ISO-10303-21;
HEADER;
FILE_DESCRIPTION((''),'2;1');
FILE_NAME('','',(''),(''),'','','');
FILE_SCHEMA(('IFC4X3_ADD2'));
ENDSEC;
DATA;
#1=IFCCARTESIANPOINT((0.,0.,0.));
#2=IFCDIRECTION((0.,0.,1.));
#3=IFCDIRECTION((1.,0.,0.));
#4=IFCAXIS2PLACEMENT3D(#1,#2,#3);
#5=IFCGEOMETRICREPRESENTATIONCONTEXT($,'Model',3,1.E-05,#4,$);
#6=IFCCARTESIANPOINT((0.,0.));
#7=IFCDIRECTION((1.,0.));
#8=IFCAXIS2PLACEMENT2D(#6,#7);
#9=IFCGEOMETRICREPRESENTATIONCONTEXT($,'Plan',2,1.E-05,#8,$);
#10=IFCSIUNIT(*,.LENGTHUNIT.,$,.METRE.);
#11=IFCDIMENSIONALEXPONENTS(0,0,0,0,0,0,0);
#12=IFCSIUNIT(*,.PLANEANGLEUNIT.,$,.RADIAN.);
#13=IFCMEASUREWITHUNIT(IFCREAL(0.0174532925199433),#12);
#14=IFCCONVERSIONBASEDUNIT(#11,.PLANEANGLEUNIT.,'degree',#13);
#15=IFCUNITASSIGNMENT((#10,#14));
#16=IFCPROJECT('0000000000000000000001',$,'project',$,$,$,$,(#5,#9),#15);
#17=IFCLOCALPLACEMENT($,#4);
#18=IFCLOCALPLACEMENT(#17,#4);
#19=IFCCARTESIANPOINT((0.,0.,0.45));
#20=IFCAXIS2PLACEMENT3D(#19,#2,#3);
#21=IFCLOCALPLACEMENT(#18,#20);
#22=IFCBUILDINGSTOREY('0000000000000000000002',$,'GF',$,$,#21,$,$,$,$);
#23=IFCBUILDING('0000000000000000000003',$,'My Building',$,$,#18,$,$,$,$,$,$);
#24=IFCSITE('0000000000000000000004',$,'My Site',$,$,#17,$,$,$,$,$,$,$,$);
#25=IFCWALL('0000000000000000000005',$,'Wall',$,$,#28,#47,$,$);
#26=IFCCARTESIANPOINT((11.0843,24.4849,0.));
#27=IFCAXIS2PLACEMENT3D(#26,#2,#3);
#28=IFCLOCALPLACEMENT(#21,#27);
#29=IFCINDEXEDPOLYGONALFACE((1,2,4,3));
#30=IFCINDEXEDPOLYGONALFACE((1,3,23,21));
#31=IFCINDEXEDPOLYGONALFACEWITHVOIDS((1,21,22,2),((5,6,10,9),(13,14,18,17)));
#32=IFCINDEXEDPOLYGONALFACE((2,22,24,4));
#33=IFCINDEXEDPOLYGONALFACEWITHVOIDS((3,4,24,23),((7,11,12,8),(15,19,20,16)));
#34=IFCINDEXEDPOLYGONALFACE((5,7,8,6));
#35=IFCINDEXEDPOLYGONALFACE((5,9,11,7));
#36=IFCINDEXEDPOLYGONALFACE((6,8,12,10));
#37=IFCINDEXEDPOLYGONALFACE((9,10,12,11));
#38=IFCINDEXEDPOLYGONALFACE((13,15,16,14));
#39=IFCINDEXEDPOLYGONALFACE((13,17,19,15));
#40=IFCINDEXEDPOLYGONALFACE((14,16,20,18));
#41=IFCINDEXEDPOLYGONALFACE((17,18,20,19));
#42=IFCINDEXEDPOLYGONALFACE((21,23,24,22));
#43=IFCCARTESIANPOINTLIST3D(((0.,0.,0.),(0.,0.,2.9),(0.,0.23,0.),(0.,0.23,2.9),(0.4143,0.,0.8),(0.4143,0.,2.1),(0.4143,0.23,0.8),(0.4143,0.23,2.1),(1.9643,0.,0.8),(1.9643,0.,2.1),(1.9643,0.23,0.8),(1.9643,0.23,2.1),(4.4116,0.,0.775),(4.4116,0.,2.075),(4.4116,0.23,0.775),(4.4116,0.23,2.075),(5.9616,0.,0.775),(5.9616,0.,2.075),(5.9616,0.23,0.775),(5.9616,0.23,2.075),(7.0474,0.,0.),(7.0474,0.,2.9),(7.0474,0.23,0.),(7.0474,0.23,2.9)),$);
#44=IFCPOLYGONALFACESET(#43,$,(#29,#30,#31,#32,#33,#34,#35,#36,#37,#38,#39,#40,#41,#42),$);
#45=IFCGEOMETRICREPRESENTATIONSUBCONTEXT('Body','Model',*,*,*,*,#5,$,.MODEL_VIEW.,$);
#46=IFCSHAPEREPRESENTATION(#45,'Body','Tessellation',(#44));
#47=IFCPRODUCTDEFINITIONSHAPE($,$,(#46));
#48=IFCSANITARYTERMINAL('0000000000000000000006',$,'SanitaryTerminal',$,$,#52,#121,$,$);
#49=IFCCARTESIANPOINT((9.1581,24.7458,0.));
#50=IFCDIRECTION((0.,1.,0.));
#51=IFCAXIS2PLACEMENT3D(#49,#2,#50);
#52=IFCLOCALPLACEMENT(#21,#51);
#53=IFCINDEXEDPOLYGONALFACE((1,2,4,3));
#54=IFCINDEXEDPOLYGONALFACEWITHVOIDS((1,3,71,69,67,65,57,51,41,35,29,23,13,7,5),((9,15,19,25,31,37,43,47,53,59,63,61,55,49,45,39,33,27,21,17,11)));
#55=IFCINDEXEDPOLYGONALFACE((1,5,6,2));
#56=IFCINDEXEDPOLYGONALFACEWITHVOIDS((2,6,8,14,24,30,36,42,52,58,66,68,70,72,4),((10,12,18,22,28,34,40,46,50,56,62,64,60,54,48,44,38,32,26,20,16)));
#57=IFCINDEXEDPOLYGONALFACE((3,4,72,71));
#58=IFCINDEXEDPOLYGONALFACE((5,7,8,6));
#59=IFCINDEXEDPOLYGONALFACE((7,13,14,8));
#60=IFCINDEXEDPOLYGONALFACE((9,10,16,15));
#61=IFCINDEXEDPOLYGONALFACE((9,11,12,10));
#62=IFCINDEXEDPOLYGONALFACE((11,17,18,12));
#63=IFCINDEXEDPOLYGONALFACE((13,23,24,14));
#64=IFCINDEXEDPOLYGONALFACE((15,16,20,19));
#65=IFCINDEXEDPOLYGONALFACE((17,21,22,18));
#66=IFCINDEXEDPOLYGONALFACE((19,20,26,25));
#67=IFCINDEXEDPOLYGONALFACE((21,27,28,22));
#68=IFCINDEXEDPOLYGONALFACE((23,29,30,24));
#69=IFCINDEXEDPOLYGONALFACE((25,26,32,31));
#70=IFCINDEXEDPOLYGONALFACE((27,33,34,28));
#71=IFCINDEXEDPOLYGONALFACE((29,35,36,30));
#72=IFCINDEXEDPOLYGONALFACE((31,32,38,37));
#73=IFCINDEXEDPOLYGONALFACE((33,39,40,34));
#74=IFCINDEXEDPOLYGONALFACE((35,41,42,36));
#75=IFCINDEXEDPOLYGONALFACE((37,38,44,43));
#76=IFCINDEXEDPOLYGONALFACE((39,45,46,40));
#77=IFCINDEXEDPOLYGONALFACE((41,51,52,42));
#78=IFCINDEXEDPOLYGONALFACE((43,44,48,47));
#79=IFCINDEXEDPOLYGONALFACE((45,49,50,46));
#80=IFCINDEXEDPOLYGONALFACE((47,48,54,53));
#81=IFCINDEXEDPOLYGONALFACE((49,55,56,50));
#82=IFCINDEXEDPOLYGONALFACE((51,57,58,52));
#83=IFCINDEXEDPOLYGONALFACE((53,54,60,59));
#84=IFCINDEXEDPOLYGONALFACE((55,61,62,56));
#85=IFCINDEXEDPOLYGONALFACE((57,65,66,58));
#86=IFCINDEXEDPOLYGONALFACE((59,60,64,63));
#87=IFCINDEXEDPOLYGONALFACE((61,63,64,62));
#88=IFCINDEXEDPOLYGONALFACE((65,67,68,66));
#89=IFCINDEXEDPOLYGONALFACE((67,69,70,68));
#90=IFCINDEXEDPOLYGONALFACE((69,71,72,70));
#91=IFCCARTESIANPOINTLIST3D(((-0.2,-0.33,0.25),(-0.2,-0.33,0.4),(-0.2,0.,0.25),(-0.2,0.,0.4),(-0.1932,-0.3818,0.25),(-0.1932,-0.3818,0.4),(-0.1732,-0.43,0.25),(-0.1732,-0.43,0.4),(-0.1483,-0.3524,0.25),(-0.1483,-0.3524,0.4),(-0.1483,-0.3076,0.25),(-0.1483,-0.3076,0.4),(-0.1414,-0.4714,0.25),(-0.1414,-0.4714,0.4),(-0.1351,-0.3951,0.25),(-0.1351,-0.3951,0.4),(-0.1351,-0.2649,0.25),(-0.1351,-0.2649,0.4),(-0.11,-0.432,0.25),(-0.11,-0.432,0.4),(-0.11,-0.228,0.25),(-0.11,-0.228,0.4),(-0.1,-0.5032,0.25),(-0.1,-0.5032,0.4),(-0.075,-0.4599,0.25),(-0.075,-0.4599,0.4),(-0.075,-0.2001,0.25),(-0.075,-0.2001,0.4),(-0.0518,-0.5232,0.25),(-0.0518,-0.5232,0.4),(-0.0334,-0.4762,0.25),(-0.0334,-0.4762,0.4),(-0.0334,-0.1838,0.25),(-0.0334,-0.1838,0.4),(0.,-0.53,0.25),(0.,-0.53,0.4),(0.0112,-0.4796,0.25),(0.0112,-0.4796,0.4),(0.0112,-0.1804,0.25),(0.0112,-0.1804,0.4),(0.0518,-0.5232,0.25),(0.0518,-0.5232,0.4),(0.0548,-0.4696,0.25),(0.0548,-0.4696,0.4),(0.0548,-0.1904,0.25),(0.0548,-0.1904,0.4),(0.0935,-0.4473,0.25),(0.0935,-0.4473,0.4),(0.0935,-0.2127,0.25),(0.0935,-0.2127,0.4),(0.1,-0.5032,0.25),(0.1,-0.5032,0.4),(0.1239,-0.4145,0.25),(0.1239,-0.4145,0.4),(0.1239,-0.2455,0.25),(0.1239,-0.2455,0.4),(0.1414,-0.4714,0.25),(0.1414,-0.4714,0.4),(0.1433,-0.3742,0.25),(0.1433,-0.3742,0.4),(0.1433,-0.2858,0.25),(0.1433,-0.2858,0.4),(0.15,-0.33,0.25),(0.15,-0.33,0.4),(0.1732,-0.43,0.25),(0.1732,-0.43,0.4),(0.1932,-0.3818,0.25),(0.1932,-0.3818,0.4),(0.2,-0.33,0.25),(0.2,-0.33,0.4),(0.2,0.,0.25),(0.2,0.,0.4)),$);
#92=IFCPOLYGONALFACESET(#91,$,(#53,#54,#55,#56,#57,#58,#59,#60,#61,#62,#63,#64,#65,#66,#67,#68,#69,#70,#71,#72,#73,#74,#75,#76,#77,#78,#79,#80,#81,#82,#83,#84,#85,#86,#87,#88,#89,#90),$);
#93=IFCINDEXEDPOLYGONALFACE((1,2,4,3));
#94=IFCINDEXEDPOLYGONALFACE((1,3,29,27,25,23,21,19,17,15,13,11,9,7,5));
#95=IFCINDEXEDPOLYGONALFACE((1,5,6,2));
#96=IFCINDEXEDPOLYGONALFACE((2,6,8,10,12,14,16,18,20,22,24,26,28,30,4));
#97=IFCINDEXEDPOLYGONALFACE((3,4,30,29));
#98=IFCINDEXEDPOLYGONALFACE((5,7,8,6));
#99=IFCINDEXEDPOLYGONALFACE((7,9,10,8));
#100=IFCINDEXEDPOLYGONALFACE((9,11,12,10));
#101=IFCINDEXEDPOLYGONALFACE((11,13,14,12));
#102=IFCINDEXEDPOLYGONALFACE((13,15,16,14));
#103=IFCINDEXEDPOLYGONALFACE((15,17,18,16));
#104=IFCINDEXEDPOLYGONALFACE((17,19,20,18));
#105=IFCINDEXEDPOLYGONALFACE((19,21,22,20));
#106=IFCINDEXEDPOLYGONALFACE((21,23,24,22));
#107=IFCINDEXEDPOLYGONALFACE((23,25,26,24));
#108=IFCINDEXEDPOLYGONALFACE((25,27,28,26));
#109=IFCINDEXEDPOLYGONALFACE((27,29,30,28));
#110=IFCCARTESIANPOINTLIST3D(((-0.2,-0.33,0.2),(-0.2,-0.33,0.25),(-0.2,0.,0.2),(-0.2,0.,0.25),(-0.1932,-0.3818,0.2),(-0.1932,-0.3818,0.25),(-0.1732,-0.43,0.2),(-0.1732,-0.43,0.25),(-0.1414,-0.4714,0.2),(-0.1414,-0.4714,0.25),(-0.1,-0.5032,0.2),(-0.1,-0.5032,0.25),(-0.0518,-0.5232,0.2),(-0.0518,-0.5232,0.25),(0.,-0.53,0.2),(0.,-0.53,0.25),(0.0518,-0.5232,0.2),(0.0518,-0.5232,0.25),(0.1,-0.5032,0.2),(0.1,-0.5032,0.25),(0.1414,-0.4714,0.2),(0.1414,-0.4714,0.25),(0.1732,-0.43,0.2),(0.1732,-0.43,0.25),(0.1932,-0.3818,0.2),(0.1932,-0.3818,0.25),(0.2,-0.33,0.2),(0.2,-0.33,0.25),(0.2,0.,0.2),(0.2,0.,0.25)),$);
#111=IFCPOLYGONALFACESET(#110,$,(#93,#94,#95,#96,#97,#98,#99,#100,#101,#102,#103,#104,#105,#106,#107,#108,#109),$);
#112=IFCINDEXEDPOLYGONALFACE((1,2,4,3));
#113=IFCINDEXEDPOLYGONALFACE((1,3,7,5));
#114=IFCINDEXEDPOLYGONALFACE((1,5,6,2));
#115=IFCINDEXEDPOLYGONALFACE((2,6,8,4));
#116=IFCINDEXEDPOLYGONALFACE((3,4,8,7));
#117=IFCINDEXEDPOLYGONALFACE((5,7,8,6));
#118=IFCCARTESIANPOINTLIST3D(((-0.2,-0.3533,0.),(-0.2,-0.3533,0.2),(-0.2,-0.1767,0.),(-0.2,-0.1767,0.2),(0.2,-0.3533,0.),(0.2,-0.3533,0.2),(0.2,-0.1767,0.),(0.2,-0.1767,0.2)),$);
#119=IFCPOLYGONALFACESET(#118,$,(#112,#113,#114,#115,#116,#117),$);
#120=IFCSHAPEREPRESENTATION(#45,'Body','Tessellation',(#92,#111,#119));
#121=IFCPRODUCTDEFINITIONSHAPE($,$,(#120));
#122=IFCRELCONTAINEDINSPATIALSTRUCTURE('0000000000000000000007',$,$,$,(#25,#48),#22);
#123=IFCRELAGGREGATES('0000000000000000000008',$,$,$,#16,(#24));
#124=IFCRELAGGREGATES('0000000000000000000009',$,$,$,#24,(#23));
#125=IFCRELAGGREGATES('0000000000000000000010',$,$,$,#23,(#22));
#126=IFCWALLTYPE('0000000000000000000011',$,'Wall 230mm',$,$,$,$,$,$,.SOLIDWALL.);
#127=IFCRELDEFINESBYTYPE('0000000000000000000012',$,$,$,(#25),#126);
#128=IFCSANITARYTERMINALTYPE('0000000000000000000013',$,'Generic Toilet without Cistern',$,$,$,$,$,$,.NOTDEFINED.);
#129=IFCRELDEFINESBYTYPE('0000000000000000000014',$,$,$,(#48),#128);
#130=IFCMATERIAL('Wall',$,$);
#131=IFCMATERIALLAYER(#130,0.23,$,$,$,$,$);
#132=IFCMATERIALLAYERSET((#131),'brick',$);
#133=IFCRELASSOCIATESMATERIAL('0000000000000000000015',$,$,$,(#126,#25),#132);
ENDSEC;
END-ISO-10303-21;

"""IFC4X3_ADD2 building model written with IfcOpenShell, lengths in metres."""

from ifc_helpers import new_model, entity, si_unit, converted_unit, frame, frame_2d, origin_with_axes, origin_2d_with_axis, place, context, subcontext, project, spatial, line, arc, indexed_curve, circle_curve, outline, extrude, shape, source, transform, mapped, material, layer, layer_set, layer_usage, type_object, type_shapes, element, save


model = new_model("IFC4X3_ADD2")

# Units and contexts
model_context = context("Model", 3, precision=1e-05, world=origin_with_axes())
plan_context = context("Plan", 2, precision=1e-05, world=origin_2d_with_axis())
body_context_1 = subcontext(model_context, "Body", "Model", "MODEL_VIEW")
body_context_2 = subcontext(plan_context, "Body", "Plan", "PLAN_VIEW")
ifc_project = project(units=[si_unit("LENGTHUNIT", "METRE"), converted_unit("PLANEANGLEUNIT", "degree", entity("IfcReal", 0.0174532925199433), si_unit("PLANEANGLEUNIT", "RADIAN"), dimensions=[0, 0, 0, 0, 0, 0, 0])], contexts=[model_context, plan_context])

# Site, building, storey
site_placement = place(None, origin_with_axes())
site = spatial("IfcSite", under=ifc_project, at=site_placement, Name="My Site")
building_placement = place(site_placement, origin_with_axes())
building = spatial("IfcBuilding", under=site, at=building_placement, Name="My Building")
storey_placement = place(building_placement, frame((0.0, 0.0, 0.45), z_axis=(0.0, 0.0, 1.0), x_axis=(1.0, 0.0, 0.0)))
storey = spatial("IfcBuildingStorey", under=building, at=storey_placement, Name="GF")

# Shared definitions
ifc_material_1 = material(Name="Wall")
ifc_layer_1 = layer(ifc_material_1, 0.23)
ifc_layer_set_1 = layer_set([ifc_layer_1], Name="brick")
wall_type_1 = type_object("IfcWallType", Name="Wall 230mm", PredefinedType="SOLIDWALL", material=ifc_layer_set_1)

# Wall, openings
ifc_layer_usage_1 = layer_usage(ifc_layer_set_1, "AXIS2", "POSITIVE", 0.0)
wall_1_placement = place(storey_placement, frame((11.0843, 24.4849, 0.0), z_axis=(0.0, 0.0, 1.0), x_axis=(1.0, 0.0, 0.0)))
wall_1 = element("IfcWall", 1, at=wall_1_placement, inside=storey, type_object=wall_type_1, material=ifc_layer_usage_1, Name="Wall", context=body_context_1, shape_type="SweptSolid", body=[
    extrude(outline(indexed_curve([(0.0, 0.0), (0.0, 0.23), (7.0474, 0.23), (7.0474, 0.0), (0.0, 0.0)], self_intersect=False)), origin_with_axes(), (0.0, 0.0, 1.0), 2.9),
])
shared_shape_1 = source(origin_with_axes(), body_context_1, "Body", "SweptSolid", [
    extrude(outline(indexed_curve([(0.0, 0.0), (1.55, 0.0), (1.55, 1.3), (0.0, 1.3)], segments=[line(1, 2, 3, 4, 1)])), frame((-0.775, -0.6, 0.0), z_axis=(0.0, -1.0, 0.0), x_axis=(1.0, 0.0, 0.0)), (0.0, 0.0, -1.0), 1.2),
])
opening_1_placement = place(wall_1_placement, frame((5.1866, 0.2, 0.775), z_axis=(0.0, 0.0, 1.0), x_axis=(-1.0, 0.0, 0.0)))
element("IfcOpeningElement", 2, at=opening_1_placement, cuts=wall_1, PredefinedType="OPENING", context=body_context_1, shape_type="MappedRepresentation", body=[
    mapped(shared_shape_1, transform((0.0, 0.0, 0.0), x_axis=(1.0, 0.0, 0.0), y_axis=(0.0, 1.0, 0.0), z_axis=(0.0, 0.0, 1.0), scale=1.0)),
])
opening_2_placement = place(wall_1_placement, frame((1.1893, 0.0, 0.8), z_axis=(0.0, 0.0, 1.0), x_axis=(1.0, 0.0, 0.0)))
element("IfcOpeningElement", 3, at=opening_2_placement, cuts=wall_1, PredefinedType="OPENING", context=body_context_1, shape_type="MappedRepresentation", body=[
    mapped(shared_shape_1, transform((0.0, 0.0, 0.0), x_axis=(1.0, 0.0, 0.0), y_axis=(0.0, 1.0, 0.0), z_axis=(0.0, 0.0, 1.0), scale=1.0)),
])

# Sanitary terminal
sanitary_terminal_type_1 = type_object("IfcSanitaryTerminalType", Name="Generic Toilet without Cistern", PredefinedType="NOTDEFINED")
shared_shape_2 = source(origin_with_axes(), body_context_1, "Body", "SweptSolid", [
    extrude(outline(indexed_curve([(-0.2, 0.0), (0.2, 0.0), (0.2, -0.33), (0.1414, -0.4714), (0.0, -0.53), (-0.1414, -0.4714), (-0.2, -0.33)], segments=[line(1, 2), line(2, 3), arc(3, 4, 5), arc(5, 6, 7), line(7, 1)]), holes=[circle_curve(frame_2d((0.0, -0.33)), 0.15)]), frame((0.0, 0.0, 0.25), z_axis=(0.0, 0.0, 1.0), x_axis=(1.0, 0.0, 0.0)), (0.0, 0.0, 1.0), 0.15),
    extrude(outline(indexed_curve([(-0.2, 0.0), (0.2, 0.0), (0.2, -0.33), (0.1414, -0.4714), (0.0, -0.53), (-0.1414, -0.4714), (-0.2, -0.33)], segments=[line(1, 2), line(2, 3), arc(3, 4, 5), arc(5, 6, 7), line(7, 1)])), frame((0.0, 0.0, 0.2), z_axis=(0.0, 0.0, 1.0), x_axis=(1.0, 0.0, 0.0)), (0.0, 0.0, 1.0), 0.05),
    extrude(outline(indexed_curve([(-0.2, -0.1767), (0.2, -0.1767), (0.2, -0.3533), (-0.2, -0.3533)], segments=[line(1, 2, 3, 4, 1)])), origin_with_axes(), (0.0, 0.0, 1.0), 0.2),
])
shared_shape_3 = source(origin_with_axes(), body_context_2, "Body", "Annotation2D", [
    entity("IfcGeometricCurveSet", [entity("IfcIndexedPolyCurve", entity("IfcCartesianPointList2D", [[-0.1068, -0.124], [-0.0957, -0.1129], [-0.0804, -0.1088], [0.0804, -0.1088], [0.0957, -0.1129], [0.1068, -0.124], [0.1109, -0.1393], [0.1109, -0.3476], [0.1025, -0.3926], [0.0784, -0.4308], [0.0424, -0.4563], [0.0, -0.4652], [-0.0424, -0.4563], [-0.0784, -0.4308], [-0.1025, -0.3926], [-0.1109, -0.3476], [-0.1109, -0.1393]]), [entity("IfcLineIndex", [1, 2, 3, 4, 5, 6, 7, 8, 9, 10, 11, 12, 13, 14, 15, 16, 17, 1])]), entity("IfcIndexedPolyCurve", entity("IfcCartesianPointList2D", [[-0.1962, -0.2314], [-0.1848, -0.301], [-0.1764, -0.3339], [-0.1663, -0.3651], [-0.1546, -0.3944], [-0.1414, -0.4213], [-0.1269, -0.4458], [-0.1111, -0.4675], [-0.0943, -0.4862], [-0.0765, -0.5018], [-0.0581, -0.514], [-0.039, -0.5229], [-0.0196, -0.5282], [0.0, -0.53], [0.0196, -0.5282], [0.039, -0.5229], [0.0581, -0.514], [0.0765, -0.5018], [0.0943, -0.4862], [0.1111, -0.4675], [0.1269, -0.4458], [0.1414, -0.4213], [0.1546, -0.3944], [0.1663, -0.3651], [0.1764, -0.3339], [0.1848, -0.301], [0.1962, -0.2314], [0.2, -0.159], [0.1872, 0.0], [-0.1872, 0.0], [-0.2, -0.159]]), [entity("IfcLineIndex", [1, 2, 3, 4, 5, 6, 7, 8, 9, 10, 11, 12, 13, 14, 15, 16, 17, 18, 19, 20, 21, 22, 23, 24, 25, 26, 27, 28, 29, 30, 31, 1])])]),
])
type_shapes(sanitary_terminal_type_1, [shared_shape_2, shared_shape_3])
for number, where, z_axis, x_axis, name in (
    (4, (9.1581, 24.7458, 0.0), (0.0, 0.0, 1.0), (0.0, 1.0, 0.0), "SanitaryTerminal"),
):
    element("IfcSanitaryTerminal", number, at=place(storey_placement, frame(where, z_axis=z_axis, x_axis=x_axis)), inside=storey, type_object=sanitary_terminal_type_1, Name=name, shapes=[
        shape(body_context_1, "Body", "MappedRepresentation", [mapped(shared_shape_2, transform((0.0, 0.0, 0.0), x_axis=(1.0, 0.0, 0.0), y_axis=(0.0, 1.0, 0.0), z_axis=(0.0, 0.0, 1.0), scale=1.0))]),
        shape(body_context_2, "Body", "MappedRepresentation", [mapped(shared_shape_3, transform((0.0, 0.0, 0.0), x_axis=(1.0, 0.0, 0.0), y_axis=(0.0, 1.0, 0.0), z_axis=(0.0, 0.0, 1.0), scale=1.0))]),
    ])

save(model, "model.ifc")
